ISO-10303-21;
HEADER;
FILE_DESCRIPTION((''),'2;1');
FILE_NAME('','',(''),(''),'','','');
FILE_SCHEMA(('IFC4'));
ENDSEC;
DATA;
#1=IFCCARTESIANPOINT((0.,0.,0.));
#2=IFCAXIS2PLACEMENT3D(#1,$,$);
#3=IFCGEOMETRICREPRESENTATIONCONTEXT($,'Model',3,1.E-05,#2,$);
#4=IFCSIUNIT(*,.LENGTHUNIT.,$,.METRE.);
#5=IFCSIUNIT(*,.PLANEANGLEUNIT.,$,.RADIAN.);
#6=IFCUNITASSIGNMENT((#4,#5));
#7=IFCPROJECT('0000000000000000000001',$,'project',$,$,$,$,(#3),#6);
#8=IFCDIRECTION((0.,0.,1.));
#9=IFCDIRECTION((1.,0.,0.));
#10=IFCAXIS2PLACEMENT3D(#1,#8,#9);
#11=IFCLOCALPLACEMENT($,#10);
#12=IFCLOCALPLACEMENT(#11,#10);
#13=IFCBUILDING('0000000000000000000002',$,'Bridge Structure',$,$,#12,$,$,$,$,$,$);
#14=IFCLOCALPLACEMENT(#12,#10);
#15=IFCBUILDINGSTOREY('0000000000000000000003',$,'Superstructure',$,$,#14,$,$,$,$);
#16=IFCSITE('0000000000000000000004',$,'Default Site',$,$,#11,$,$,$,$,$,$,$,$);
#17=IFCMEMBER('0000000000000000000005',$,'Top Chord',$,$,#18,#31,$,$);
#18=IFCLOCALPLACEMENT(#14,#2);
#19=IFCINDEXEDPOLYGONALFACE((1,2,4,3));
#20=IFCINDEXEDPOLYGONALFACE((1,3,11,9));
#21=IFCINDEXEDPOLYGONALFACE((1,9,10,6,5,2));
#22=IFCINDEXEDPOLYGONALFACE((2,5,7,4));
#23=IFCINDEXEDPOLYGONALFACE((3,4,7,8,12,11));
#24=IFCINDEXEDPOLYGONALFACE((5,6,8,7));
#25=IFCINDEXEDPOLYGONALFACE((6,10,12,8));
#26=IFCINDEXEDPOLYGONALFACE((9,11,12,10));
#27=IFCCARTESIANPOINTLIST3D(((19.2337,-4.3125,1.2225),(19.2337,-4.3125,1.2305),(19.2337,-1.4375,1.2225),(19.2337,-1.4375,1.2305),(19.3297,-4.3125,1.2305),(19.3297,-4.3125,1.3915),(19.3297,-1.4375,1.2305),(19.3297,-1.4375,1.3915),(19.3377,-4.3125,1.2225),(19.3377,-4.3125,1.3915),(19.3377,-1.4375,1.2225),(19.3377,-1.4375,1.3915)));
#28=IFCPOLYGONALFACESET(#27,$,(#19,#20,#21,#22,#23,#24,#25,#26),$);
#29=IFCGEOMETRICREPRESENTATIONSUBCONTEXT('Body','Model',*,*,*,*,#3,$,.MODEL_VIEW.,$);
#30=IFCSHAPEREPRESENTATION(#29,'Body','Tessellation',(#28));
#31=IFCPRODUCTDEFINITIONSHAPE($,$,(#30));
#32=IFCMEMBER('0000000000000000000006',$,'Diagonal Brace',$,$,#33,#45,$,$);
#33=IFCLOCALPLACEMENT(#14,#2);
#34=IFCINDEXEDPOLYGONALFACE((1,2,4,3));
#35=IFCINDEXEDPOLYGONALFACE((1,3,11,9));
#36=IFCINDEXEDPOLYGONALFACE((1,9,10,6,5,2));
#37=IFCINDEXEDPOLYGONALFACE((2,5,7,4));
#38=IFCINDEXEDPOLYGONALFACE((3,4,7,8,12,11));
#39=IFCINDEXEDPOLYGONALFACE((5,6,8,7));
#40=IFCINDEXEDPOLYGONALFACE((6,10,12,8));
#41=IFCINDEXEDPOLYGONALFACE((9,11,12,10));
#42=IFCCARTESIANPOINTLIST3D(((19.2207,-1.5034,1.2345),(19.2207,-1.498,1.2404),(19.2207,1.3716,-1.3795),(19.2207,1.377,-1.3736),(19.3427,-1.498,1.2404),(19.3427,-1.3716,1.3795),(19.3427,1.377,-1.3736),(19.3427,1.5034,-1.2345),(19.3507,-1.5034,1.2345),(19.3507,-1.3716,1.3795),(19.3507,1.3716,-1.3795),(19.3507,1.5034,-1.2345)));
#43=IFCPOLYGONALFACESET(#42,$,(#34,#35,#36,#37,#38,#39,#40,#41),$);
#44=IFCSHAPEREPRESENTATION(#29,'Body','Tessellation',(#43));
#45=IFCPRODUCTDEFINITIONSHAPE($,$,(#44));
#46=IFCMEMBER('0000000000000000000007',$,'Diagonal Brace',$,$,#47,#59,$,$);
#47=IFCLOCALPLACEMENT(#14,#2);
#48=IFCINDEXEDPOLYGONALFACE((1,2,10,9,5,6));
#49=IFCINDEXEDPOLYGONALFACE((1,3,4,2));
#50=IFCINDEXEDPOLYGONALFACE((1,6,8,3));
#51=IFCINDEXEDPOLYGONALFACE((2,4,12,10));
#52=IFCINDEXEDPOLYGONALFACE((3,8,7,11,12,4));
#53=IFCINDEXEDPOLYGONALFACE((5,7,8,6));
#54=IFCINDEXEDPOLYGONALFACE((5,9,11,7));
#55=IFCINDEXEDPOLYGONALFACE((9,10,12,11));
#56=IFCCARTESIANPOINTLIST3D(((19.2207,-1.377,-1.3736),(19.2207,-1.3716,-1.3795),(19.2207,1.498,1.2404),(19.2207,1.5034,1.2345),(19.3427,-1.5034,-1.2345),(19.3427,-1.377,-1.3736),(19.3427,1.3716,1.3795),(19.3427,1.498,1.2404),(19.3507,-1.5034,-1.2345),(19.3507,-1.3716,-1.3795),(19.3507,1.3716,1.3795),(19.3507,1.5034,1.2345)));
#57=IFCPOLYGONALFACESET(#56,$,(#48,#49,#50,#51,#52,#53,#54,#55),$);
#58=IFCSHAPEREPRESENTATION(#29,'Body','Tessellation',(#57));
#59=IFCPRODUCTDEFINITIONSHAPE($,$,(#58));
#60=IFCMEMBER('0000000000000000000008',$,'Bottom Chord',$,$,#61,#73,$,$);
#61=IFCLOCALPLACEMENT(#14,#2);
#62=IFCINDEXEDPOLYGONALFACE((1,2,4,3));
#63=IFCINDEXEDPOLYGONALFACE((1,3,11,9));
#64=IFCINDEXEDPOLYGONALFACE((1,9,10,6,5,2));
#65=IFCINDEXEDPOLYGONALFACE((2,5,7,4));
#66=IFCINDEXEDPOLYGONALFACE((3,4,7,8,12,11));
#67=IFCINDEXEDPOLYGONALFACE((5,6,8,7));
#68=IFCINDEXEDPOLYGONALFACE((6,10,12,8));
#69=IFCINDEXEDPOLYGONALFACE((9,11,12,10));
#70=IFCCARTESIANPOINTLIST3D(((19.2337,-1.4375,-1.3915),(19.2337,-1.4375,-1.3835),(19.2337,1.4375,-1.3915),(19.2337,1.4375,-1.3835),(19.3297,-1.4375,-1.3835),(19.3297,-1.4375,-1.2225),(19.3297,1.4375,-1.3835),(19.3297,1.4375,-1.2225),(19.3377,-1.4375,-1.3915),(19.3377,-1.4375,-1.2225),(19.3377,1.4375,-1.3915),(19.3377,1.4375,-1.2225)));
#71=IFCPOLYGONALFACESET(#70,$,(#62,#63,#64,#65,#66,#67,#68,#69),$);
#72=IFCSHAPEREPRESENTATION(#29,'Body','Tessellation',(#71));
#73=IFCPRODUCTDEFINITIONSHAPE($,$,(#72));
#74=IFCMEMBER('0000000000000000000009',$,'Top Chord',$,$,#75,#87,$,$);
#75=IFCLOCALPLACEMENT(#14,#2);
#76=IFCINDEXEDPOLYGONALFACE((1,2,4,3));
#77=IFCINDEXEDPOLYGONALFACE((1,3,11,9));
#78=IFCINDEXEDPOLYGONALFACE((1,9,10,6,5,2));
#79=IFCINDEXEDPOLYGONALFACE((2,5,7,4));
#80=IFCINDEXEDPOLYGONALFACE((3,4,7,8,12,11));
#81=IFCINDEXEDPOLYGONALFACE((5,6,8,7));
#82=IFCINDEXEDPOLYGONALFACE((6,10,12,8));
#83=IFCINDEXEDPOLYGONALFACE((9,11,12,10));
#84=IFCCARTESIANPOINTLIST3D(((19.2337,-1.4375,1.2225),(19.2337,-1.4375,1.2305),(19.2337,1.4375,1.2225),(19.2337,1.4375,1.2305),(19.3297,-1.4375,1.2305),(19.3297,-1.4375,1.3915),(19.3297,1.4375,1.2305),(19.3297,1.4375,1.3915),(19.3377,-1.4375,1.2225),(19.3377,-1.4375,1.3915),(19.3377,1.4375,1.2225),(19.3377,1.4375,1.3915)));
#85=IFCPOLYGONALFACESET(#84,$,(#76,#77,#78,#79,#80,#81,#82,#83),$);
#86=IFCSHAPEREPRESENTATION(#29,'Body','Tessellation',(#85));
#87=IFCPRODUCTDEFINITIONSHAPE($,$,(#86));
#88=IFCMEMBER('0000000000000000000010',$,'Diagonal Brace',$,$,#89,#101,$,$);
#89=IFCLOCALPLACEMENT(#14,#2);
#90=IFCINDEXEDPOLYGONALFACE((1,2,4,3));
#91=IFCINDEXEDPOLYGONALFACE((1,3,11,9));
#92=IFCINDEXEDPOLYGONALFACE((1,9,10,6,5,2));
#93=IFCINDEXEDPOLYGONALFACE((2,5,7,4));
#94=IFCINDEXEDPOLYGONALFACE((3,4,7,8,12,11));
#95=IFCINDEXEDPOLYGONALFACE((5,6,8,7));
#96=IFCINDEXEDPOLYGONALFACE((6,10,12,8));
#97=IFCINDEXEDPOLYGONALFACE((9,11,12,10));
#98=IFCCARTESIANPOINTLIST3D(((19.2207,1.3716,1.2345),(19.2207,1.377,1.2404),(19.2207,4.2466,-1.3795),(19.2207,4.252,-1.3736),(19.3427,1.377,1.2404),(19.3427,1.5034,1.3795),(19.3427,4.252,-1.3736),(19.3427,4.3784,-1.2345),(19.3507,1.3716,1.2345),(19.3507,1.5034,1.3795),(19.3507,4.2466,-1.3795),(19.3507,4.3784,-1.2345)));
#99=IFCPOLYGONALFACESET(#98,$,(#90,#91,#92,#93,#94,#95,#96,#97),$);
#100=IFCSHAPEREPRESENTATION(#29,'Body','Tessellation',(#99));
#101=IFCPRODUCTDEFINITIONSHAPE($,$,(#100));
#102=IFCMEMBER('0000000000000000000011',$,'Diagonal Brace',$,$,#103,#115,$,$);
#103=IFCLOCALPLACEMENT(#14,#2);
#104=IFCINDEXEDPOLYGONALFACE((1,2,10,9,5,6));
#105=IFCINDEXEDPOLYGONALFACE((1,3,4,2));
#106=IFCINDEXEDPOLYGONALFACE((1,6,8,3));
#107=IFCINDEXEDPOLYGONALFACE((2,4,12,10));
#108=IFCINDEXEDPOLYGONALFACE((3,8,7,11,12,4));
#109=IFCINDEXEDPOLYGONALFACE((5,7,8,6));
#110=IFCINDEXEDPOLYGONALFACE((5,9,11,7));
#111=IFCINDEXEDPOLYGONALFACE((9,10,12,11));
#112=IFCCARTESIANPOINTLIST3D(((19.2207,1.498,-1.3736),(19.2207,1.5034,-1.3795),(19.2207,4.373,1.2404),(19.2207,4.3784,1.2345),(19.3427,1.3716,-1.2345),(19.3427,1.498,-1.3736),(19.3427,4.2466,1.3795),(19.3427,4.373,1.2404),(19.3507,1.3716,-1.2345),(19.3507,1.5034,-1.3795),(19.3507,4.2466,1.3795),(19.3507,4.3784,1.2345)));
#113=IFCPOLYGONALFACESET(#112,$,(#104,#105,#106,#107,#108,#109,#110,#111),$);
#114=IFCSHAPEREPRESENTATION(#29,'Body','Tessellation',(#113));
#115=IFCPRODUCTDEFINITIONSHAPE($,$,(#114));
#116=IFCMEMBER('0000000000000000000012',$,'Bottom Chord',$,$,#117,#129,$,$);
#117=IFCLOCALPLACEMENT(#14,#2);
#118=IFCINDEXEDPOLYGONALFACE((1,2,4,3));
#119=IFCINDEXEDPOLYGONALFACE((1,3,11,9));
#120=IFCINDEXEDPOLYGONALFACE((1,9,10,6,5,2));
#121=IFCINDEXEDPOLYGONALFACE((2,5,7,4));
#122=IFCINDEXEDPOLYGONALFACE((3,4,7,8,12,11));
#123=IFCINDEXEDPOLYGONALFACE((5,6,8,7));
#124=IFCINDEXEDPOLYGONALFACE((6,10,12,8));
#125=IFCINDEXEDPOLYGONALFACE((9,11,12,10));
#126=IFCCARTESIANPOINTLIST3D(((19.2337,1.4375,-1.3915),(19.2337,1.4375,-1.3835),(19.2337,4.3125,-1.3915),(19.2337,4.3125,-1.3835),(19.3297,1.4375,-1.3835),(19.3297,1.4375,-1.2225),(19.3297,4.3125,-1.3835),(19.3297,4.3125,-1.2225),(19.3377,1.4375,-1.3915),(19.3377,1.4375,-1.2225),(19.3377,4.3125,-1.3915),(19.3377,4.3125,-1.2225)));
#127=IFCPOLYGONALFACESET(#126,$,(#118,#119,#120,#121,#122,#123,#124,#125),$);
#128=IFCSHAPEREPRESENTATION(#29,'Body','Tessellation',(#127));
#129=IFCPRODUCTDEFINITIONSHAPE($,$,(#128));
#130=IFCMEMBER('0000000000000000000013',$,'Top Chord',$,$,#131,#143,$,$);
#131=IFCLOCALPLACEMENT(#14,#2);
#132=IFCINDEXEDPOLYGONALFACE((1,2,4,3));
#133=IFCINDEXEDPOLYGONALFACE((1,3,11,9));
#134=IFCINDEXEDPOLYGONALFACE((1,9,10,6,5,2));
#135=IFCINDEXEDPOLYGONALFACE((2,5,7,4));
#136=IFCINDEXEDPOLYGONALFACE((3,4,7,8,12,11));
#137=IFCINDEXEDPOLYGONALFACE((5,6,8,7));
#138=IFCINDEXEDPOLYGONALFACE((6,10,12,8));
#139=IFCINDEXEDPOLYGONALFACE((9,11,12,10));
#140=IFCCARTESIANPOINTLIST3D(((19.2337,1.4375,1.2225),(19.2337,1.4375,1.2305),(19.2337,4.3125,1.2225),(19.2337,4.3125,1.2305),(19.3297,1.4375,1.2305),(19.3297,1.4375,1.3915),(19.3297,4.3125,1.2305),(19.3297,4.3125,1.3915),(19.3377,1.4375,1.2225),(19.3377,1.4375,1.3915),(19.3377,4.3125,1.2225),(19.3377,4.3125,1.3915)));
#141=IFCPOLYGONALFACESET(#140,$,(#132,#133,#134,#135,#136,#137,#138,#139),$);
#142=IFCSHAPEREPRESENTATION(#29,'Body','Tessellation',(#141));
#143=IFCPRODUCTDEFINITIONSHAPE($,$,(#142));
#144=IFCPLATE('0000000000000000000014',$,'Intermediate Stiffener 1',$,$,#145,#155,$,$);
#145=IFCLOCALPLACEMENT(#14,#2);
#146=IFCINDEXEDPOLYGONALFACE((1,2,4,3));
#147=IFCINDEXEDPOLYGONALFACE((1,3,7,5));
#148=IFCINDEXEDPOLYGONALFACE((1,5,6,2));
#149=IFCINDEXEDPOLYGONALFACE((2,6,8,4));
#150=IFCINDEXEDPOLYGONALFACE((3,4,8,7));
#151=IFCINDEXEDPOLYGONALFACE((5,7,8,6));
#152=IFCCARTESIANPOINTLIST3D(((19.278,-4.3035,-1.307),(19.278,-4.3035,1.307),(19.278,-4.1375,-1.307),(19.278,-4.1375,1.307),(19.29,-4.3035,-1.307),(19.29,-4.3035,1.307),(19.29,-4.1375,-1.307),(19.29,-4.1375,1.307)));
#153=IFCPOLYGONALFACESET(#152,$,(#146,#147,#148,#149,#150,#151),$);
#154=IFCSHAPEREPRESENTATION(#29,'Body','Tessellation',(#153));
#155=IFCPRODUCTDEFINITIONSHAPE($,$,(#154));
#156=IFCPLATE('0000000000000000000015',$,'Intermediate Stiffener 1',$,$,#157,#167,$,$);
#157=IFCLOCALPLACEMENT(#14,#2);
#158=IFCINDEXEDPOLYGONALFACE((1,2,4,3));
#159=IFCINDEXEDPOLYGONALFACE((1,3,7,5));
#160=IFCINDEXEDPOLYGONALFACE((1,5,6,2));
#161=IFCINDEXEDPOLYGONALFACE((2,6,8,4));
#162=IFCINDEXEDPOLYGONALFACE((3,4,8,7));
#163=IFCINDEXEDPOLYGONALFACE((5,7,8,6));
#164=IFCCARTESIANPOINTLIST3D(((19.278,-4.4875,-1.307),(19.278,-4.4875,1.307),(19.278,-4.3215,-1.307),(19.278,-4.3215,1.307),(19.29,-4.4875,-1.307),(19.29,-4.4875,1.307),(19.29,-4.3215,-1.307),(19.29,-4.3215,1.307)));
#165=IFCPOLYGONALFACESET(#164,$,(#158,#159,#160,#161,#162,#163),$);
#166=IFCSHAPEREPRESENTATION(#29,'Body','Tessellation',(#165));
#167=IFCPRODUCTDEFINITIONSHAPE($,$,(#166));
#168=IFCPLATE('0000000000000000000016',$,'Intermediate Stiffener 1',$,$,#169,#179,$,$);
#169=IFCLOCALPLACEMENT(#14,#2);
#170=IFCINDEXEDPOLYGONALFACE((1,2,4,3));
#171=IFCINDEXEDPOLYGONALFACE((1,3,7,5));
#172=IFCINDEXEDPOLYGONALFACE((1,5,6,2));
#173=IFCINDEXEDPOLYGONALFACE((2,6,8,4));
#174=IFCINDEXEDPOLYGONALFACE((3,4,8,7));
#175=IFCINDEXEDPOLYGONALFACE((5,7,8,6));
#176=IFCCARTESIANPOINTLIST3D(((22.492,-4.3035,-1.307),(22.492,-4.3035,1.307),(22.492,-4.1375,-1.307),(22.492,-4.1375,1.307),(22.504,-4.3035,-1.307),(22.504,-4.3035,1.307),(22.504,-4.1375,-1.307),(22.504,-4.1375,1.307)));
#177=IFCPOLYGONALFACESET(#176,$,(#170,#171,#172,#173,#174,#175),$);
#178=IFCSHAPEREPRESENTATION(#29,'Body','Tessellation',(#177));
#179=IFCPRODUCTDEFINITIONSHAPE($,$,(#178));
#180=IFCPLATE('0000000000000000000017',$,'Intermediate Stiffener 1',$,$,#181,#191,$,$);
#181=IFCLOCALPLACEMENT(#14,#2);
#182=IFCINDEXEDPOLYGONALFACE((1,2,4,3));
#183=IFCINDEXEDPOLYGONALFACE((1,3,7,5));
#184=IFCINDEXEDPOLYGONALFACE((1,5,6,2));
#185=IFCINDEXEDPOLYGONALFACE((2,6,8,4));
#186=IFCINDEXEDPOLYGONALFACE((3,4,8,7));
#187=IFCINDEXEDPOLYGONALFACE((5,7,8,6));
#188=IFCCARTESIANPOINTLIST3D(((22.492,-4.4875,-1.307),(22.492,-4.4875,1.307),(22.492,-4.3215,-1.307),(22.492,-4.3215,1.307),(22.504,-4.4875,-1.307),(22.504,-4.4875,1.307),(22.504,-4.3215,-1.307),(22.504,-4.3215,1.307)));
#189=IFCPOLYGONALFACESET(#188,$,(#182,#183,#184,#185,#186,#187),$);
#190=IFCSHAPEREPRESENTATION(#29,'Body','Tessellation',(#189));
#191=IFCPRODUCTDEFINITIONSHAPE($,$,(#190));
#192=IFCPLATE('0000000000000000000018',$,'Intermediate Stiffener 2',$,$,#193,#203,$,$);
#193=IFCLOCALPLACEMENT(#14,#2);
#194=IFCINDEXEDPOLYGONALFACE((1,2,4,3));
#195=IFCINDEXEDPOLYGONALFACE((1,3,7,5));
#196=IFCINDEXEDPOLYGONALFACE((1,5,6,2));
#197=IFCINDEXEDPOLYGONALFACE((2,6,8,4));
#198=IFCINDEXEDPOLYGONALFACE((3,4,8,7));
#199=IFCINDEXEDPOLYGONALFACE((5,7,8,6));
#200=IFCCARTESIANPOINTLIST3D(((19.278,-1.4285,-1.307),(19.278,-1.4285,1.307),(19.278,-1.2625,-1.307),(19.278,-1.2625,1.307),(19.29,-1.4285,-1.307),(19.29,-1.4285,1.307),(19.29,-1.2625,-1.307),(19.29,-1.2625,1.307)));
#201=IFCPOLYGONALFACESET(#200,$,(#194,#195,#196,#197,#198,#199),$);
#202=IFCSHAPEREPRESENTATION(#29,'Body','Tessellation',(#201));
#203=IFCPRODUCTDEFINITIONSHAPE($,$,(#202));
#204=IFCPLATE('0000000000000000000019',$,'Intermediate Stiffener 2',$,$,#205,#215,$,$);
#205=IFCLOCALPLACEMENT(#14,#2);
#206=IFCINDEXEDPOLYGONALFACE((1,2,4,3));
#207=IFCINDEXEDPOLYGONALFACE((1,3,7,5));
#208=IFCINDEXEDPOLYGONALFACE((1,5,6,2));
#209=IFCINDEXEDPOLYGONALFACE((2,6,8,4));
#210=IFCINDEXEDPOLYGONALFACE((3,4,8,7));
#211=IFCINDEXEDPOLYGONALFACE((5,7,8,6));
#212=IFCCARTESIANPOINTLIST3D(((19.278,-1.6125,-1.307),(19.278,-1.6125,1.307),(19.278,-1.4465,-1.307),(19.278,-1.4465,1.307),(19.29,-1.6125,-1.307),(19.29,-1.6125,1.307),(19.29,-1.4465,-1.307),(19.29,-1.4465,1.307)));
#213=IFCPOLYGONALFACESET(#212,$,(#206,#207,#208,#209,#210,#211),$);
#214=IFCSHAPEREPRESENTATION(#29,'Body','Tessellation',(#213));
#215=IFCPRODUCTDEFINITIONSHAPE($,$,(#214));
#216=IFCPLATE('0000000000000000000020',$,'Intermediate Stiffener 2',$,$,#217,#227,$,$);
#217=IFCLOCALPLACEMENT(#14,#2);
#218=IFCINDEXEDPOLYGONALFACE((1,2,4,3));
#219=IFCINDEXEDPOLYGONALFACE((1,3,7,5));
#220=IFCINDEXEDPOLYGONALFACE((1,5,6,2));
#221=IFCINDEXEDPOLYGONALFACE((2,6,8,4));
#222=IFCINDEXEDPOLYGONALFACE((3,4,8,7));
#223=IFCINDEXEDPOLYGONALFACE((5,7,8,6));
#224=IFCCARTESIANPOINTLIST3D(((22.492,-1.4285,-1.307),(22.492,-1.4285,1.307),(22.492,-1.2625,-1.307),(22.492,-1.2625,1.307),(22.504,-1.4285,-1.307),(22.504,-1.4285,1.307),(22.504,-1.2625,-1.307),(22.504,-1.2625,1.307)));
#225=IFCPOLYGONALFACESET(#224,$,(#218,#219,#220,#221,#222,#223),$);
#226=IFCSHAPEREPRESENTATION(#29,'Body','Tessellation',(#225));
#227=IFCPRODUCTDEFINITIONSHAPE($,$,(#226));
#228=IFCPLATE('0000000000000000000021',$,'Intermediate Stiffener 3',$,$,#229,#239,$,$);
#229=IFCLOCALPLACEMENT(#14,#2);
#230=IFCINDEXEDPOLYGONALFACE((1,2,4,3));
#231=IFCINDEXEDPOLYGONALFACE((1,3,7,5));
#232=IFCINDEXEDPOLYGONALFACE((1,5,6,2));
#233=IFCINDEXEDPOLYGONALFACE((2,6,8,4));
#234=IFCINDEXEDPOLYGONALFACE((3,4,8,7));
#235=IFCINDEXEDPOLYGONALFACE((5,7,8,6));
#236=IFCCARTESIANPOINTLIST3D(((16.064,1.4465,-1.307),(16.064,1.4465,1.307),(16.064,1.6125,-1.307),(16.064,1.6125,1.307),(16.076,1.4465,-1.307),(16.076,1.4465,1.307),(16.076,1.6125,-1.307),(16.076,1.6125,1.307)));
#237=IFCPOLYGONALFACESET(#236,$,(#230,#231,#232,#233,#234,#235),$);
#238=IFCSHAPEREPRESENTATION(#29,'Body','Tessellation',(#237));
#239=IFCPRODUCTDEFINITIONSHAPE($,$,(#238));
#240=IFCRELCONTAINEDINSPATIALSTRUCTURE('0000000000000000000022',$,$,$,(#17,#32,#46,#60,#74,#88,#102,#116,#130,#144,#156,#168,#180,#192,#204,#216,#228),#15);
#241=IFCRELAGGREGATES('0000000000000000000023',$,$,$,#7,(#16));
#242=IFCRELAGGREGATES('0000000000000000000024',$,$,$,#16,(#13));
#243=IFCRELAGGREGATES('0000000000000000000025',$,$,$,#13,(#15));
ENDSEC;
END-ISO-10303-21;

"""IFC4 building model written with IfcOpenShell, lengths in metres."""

from ifc_helpers import new_model, si_unit, frame, origin, origin_with_axes, origin_2d_with_axis, place, context, subcontext, project, spatial, rectangle, l_section, extrude, element, save


model = new_model("IFC4")

# Units and contexts
model_context = context("Model", 3, precision=1e-05, world=origin())
body_context = subcontext(model_context, "Body", "Model", "MODEL_VIEW")
ifc_project = project(units=[si_unit("LENGTHUNIT", "METRE"), si_unit("PLANEANGLEUNIT", "RADIAN")], contexts=[model_context])

# Site, building, storey
site_placement = place(None, origin_with_axes())
site = spatial("IfcSite", under=ifc_project, at=site_placement, Name="Default Site")
building_placement = place(site_placement, origin_with_axes())
building = spatial("IfcBuilding", under=site, at=building_placement, Name="Bridge Structure")
storey_placement = place(building_placement, origin_with_axes())
storey = spatial("IfcBuildingStorey", under=building, at=storey_placement, Name="Superstructure")

# Members
for number, where, z_axis, x_axis, name in (
    (1, (19.2857, -4.3125, 1.307), (0.0, 1.0, 0.0), (-1.0, 0.0, 0.0), "Top Chord"),
):
    element("IfcMember", number, at=place(storey_placement, frame(where, z_axis=z_axis, x_axis=x_axis)), inside=storey, Name=name, context=body_context, shape_type="SweptSolid", body=[
        extrude(l_section(Depth=0.169, Width=0.104, Thickness=0.008, at=origin_2d_with_axis()), origin_with_axes(), (0.0, 0.0, 1.0), 2.875),
    ])
for number, where, z_axis, x_axis, name in (
    (2, (19.2857, -1.4375, 1.307), (0.0, 0.739893, -0.672724), (-1.0, 0.0, 0.0), "Diagonal Brace"),
    (3, (19.2857, -1.4375, -1.307), (0.0, 0.739893, 0.672724), (-1.0, 0.0, 0.0), "Diagonal Brace"),
):
    element("IfcMember", number, at=place(storey_placement, frame(where, z_axis=z_axis, x_axis=x_axis)), inside=storey, Name=name, context=body_context, shape_type="SweptSolid", body=[
        extrude(l_section(Depth=0.196, Width=0.13, Thickness=0.008, at=origin_2d_with_axis()), origin_with_axes(), (0.0, 0.0, 1.0), 3.8857),
    ])
for number, where, z_axis, x_axis, name in (
    (4, (19.2857, -1.4375, -1.307), (0.0, 1.0, 0.0), (-1.0, 0.0, 0.0), "Bottom Chord"),
    (5, (19.2857, -1.4375, 1.307), (0.0, 1.0, 0.0), (-1.0, 0.0, 0.0), "Top Chord"),
):
    element("IfcMember", number, at=place(storey_placement, frame(where, z_axis=z_axis, x_axis=x_axis)), inside=storey, Name=name, context=body_context, shape_type="SweptSolid", body=[
        extrude(l_section(Depth=0.169, Width=0.104, Thickness=0.008, at=origin_2d_with_axis()), origin_with_axes(), (0.0, 0.0, 1.0), 2.875),
    ])
for number, where, z_axis, x_axis, name in (
    (6, (19.2857, 1.4375, 1.307), (0.0, 0.739893, -0.672724), (-1.0, 0.0, 0.0), "Diagonal Brace"),
    (7, (19.2857, 1.4375, -1.307), (0.0, 0.739893, 0.672724), (-1.0, 0.0, 0.0), "Diagonal Brace"),
):
    element("IfcMember", number, at=place(storey_placement, frame(where, z_axis=z_axis, x_axis=x_axis)), inside=storey, Name=name, context=body_context, shape_type="SweptSolid", body=[
        extrude(l_section(Depth=0.196, Width=0.13, Thickness=0.008, at=origin_2d_with_axis()), origin_with_axes(), (0.0, 0.0, 1.0), 3.8857),
    ])
for number, where, z_axis, x_axis, name in (
    (8, (19.2857, 1.4375, -1.307), (0.0, 1.0, 0.0), (-1.0, 0.0, 0.0), "Bottom Chord"),
    (9, (19.2857, 1.4375, 1.307), (0.0, 1.0, 0.0), (-1.0, 0.0, 0.0), "Top Chord"),
):
    element("IfcMember", number, at=place(storey_placement, frame(where, z_axis=z_axis, x_axis=x_axis)), inside=storey, Name=name, context=body_context, shape_type="SweptSolid", body=[
        extrude(l_section(Depth=0.169, Width=0.104, Thickness=0.008, at=origin_2d_with_axis()), origin_with_axes(), (0.0, 0.0, 1.0), 2.875),
    ])

# Plates
for number, where, z_axis, x_axis, name in (
    (10, (19.284, -4.2205, -1.307), (0.0, 0.0, 1.0), (1.0, 0.0, 0.0), "Intermediate Stiffener 1"),
    (11, (19.284, -4.4045, -1.307), (0.0, 0.0, 1.0), (1.0, 0.0, 0.0), "Intermediate Stiffener 1"),
    (12, (22.498, -4.2205, -1.307), (0.0, 0.0, 1.0), (1.0, 0.0, 0.0), "Intermediate Stiffener 1"),
    (13, (22.498, -4.4045, -1.307), (0.0, 0.0, 1.0), (1.0, 0.0, 0.0), "Intermediate Stiffener 1"),
    (14, (19.284, -1.3455, -1.307), (0.0, 0.0, 1.0), (1.0, 0.0, 0.0), "Intermediate Stiffener 2"),
    (15, (19.284, -1.5295, -1.307), (0.0, 0.0, 1.0), (1.0, 0.0, 0.0), "Intermediate Stiffener 2"),
    (16, (22.498, -1.3455, -1.307), (0.0, 0.0, 1.0), (1.0, 0.0, 0.0), "Intermediate Stiffener 2"),
    (17, (16.07, 1.5295, -1.307), (0.0, 0.0, 1.0), (1.0, 0.0, 0.0), "Intermediate Stiffener 3"),
):
    element("IfcPlate", number, at=place(storey_placement, frame(where, z_axis=z_axis, x_axis=x_axis)), inside=storey, Name=name, context=body_context, shape_type="SweptSolid", body=[
        extrude(rectangle(XDim=0.012, YDim=0.166, at=origin_2d_with_axis()), origin_with_axes(), (0.0, 0.0, 1.0), 2.614),
    ])

save(model, "model.ifc")
